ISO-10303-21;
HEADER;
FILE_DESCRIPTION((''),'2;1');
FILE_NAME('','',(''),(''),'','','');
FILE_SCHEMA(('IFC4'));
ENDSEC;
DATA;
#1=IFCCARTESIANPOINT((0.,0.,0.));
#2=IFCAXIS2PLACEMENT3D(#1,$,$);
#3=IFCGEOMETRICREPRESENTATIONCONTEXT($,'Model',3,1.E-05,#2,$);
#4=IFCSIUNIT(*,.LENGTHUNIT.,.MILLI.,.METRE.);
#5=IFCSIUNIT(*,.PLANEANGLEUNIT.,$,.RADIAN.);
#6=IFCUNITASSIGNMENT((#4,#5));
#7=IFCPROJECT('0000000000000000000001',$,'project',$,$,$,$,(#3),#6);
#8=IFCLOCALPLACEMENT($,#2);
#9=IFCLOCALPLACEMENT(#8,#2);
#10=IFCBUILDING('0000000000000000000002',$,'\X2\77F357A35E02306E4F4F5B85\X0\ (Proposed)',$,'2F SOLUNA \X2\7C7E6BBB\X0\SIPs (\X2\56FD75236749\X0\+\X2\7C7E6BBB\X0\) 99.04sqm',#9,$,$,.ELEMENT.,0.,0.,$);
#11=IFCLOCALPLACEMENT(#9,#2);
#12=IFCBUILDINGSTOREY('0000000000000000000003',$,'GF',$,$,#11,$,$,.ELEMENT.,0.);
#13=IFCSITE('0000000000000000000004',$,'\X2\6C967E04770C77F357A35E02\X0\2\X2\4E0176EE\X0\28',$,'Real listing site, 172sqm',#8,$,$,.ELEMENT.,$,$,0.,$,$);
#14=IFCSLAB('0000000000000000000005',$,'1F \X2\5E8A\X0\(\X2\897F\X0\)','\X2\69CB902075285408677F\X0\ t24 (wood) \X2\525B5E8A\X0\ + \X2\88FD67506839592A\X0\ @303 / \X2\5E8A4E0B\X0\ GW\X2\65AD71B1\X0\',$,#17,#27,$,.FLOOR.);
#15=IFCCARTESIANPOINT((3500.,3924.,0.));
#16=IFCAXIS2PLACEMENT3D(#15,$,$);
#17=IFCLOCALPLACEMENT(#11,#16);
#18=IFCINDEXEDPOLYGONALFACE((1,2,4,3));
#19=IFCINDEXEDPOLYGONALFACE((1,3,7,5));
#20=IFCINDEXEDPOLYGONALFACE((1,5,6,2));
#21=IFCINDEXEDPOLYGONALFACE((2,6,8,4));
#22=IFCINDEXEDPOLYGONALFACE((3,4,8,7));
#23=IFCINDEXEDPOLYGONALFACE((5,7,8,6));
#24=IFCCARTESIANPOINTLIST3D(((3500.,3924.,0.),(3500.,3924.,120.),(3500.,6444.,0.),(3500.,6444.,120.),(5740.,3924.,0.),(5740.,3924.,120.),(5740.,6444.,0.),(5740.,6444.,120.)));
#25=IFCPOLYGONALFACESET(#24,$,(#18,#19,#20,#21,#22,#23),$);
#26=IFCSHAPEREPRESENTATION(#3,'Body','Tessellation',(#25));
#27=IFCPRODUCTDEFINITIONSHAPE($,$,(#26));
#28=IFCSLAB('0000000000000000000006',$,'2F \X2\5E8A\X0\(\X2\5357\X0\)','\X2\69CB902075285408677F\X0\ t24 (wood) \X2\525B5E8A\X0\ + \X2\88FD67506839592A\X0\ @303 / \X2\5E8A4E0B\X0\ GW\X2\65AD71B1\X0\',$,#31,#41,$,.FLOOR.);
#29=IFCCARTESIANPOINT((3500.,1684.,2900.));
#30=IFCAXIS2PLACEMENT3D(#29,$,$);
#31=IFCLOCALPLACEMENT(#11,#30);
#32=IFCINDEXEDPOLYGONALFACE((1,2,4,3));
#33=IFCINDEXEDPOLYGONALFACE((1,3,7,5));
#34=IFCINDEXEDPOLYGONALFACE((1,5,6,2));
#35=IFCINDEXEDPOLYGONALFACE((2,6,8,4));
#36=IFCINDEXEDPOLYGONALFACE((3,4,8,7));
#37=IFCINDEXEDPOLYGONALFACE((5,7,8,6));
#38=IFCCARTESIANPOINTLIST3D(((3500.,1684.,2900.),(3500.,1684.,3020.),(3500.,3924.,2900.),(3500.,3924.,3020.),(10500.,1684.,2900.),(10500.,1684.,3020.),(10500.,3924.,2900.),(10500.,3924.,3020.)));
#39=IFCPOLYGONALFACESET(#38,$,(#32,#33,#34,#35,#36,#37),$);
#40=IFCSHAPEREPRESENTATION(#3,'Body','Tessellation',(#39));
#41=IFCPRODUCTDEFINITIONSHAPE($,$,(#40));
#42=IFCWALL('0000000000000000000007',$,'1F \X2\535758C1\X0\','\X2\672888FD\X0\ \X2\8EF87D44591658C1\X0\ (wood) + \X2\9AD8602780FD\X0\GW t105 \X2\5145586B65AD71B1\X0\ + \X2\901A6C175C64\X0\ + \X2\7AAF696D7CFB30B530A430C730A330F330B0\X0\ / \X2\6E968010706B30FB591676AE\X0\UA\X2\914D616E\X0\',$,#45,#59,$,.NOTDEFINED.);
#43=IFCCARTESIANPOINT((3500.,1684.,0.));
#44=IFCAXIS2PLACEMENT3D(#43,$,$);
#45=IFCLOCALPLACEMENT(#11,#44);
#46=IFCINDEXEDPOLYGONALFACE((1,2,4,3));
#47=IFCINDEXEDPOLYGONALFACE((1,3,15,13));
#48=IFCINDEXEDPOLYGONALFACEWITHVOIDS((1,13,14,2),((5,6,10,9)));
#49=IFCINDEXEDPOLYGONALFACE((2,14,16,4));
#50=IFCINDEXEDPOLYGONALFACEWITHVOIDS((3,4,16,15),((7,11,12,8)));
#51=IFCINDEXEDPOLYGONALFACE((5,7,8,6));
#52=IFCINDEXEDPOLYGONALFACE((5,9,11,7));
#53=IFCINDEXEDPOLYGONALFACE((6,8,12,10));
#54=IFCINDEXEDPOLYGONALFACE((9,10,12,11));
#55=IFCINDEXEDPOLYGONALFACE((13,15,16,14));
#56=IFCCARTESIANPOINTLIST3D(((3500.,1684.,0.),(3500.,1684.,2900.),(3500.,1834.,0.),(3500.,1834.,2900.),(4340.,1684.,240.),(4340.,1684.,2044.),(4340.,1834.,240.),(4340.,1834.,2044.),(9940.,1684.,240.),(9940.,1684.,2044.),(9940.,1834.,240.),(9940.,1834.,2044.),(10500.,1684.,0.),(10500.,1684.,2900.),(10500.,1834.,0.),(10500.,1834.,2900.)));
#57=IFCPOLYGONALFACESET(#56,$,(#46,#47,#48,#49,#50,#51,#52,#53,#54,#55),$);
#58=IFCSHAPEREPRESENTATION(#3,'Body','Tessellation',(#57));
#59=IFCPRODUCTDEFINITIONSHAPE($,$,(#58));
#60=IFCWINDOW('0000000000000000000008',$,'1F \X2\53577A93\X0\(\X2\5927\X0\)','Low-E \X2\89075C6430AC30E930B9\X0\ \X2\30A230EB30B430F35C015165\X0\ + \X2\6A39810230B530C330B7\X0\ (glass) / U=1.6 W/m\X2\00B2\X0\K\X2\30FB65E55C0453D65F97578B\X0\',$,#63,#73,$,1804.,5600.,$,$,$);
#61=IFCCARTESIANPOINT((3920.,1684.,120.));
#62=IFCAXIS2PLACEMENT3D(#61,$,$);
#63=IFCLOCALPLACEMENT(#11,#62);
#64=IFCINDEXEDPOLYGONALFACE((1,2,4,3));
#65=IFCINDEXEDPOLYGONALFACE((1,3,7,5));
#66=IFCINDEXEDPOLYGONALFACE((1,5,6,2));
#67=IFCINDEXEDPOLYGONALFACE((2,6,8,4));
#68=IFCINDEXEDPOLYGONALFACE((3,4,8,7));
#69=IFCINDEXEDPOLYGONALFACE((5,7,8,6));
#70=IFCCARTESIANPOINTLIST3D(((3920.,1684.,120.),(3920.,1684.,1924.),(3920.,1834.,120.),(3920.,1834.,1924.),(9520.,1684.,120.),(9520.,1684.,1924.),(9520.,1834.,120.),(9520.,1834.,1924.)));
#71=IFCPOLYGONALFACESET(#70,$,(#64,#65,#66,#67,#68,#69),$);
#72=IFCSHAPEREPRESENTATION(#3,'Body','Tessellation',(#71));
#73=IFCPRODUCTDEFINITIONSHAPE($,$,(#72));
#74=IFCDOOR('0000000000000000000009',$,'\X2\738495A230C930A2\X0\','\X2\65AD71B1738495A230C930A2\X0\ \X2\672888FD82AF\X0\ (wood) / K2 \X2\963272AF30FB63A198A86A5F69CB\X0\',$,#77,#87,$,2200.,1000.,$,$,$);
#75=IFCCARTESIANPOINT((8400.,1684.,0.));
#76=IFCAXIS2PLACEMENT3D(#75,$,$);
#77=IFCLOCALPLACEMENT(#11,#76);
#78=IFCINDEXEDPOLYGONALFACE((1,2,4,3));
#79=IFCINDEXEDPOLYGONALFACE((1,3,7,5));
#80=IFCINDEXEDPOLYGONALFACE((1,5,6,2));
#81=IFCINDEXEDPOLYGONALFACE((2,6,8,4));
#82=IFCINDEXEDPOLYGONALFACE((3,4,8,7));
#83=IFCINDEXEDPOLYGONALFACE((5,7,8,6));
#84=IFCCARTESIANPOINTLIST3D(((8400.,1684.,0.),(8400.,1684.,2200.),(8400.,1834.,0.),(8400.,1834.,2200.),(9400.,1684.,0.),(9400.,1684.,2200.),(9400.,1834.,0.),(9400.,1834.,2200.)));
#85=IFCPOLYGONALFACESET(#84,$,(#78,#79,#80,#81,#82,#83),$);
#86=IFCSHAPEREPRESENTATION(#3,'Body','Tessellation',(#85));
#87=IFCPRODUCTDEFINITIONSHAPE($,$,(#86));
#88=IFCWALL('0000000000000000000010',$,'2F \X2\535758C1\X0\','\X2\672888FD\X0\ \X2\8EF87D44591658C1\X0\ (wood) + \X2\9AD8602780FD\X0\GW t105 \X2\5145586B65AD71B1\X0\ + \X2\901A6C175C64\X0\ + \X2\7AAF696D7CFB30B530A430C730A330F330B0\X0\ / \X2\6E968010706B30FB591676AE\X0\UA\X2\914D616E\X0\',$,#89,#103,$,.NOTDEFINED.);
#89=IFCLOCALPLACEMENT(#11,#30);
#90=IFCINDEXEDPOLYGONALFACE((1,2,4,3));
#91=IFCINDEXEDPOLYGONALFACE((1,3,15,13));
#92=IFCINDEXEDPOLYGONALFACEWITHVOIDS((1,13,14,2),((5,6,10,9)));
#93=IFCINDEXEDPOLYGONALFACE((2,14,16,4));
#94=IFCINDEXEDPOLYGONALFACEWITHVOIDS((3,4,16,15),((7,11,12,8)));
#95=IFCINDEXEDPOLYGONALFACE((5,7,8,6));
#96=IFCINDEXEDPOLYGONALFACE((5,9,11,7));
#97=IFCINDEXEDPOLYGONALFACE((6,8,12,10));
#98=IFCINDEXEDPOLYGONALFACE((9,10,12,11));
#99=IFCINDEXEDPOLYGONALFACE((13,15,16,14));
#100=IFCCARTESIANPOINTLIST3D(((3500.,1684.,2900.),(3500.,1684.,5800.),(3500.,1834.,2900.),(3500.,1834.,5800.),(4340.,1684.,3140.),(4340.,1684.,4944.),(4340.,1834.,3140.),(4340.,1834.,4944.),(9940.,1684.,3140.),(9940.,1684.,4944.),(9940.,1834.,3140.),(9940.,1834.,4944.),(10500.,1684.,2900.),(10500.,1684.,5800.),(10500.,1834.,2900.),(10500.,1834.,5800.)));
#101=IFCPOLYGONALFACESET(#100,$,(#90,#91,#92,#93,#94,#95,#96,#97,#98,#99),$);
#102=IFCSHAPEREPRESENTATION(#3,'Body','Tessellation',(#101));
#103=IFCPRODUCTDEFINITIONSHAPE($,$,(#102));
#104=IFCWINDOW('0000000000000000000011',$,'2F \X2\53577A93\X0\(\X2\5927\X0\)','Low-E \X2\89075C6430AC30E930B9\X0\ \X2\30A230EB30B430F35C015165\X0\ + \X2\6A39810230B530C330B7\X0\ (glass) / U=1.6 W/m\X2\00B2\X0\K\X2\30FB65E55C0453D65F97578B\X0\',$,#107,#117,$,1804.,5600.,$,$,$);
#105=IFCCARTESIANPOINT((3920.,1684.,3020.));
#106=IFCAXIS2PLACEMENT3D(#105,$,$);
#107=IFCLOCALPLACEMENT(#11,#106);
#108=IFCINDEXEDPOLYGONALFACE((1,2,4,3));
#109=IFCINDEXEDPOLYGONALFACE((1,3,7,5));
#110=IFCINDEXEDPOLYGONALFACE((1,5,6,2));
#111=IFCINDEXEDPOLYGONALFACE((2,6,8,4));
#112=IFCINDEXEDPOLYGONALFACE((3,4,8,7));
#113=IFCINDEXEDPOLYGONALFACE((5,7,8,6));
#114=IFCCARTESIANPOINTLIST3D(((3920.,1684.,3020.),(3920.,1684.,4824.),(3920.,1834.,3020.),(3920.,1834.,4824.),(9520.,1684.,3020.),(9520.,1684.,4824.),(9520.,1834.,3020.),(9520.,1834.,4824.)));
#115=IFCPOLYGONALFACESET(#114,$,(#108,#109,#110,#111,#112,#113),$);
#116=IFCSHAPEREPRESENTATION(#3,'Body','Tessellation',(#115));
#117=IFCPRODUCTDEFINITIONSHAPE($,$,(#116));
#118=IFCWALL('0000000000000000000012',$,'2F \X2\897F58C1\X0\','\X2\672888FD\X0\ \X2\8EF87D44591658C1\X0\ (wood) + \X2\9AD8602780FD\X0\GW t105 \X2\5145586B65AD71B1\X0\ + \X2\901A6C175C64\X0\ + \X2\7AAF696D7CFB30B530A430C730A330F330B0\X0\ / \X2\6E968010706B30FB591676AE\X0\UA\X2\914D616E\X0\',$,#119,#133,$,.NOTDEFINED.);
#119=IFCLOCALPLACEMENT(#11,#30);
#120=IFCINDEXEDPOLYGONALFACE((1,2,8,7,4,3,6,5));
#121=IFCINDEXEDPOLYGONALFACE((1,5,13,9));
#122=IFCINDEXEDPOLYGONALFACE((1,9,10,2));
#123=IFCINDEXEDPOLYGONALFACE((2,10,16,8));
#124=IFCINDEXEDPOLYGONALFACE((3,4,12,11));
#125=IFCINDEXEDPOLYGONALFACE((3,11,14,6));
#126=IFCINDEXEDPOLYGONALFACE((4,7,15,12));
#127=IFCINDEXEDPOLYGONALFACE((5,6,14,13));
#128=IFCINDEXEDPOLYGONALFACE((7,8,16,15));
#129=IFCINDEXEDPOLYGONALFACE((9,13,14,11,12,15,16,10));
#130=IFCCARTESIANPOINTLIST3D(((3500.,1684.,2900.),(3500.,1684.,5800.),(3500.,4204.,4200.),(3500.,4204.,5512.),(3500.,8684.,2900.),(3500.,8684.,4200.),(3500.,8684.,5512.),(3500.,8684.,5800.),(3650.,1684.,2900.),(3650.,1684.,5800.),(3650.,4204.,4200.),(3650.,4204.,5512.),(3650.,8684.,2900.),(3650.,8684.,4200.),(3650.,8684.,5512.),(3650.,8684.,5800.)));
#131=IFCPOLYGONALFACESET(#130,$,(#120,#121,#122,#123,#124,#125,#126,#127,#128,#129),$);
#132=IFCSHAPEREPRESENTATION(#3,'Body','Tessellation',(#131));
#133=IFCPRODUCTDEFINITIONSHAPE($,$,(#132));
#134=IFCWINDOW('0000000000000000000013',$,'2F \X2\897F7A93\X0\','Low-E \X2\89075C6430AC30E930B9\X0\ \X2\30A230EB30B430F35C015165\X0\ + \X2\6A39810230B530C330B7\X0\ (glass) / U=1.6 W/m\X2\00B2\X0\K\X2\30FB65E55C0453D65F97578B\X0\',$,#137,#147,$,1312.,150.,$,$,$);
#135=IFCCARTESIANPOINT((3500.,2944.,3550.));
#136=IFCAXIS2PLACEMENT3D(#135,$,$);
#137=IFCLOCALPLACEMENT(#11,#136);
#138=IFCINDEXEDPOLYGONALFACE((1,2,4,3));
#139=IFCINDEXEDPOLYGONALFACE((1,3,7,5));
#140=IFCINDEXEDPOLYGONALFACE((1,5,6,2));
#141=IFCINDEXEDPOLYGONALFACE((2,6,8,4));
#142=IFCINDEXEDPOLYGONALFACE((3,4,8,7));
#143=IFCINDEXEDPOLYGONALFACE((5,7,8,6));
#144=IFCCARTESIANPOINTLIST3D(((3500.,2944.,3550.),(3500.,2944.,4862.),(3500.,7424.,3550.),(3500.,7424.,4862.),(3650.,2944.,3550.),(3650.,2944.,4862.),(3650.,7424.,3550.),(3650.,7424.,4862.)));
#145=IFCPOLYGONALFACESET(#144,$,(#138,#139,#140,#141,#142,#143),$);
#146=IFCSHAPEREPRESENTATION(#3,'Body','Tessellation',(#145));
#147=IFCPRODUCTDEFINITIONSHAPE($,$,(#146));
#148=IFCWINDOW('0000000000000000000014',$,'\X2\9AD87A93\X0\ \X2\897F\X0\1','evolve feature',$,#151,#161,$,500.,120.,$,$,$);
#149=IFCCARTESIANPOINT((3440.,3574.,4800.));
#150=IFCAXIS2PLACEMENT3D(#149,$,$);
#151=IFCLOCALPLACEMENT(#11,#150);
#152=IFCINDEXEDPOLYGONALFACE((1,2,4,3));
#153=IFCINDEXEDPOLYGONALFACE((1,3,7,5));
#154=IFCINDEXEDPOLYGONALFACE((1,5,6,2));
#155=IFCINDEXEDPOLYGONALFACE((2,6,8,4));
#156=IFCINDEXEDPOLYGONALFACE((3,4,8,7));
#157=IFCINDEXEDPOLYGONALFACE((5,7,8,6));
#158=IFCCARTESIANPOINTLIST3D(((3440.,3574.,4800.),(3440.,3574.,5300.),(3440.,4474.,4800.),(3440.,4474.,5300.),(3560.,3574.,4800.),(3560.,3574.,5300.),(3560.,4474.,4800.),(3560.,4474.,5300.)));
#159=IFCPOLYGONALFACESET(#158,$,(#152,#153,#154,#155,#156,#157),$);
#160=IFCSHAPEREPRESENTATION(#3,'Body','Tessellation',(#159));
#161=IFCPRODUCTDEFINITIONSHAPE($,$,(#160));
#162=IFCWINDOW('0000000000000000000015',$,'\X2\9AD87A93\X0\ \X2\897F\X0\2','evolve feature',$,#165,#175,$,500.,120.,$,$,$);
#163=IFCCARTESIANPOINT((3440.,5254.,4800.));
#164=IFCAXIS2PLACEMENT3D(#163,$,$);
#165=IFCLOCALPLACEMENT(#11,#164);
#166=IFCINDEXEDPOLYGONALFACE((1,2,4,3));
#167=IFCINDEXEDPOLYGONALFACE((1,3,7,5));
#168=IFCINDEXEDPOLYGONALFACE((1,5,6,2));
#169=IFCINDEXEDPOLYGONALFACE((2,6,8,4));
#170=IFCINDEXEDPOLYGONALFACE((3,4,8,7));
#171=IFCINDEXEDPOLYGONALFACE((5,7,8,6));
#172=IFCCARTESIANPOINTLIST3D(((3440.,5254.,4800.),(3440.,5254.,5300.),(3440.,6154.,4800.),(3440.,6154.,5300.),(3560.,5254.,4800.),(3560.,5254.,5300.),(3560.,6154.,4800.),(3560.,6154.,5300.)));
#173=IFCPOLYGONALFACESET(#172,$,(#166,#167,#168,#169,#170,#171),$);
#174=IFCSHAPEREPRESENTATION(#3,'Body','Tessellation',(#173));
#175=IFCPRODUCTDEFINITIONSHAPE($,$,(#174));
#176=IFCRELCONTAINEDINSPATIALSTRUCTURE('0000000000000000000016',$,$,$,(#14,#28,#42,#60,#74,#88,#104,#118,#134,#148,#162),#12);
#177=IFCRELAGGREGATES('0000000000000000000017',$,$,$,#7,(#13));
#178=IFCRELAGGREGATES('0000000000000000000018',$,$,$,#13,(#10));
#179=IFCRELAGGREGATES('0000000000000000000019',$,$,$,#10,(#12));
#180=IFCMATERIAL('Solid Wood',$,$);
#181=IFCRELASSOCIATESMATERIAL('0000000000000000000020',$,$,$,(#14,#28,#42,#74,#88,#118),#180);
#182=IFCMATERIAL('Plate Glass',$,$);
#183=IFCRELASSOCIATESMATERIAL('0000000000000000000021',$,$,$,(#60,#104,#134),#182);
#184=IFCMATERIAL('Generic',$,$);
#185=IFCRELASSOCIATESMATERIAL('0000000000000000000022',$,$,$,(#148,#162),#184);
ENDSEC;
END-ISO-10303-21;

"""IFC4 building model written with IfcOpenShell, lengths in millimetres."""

from ifc_helpers import new_model, si_unit, frame, frame_2d, origin, place, context, project, spatial, rectangle, extrude, material, element, fill, save


model = new_model("IFC4")

# Units and contexts
model_context = context("Model", 3, precision=1e-05, world=origin())
ifc_project = project(units=[si_unit("LENGTHUNIT", "METRE", prefix="MILLI"), si_unit("PLANEANGLEUNIT", "RADIAN")], contexts=[model_context])

# Site, building, storey
site_placement = place(None, origin())
site = spatial("IfcSite", under=ifc_project, at=site_placement, Name="沖縄県石垣市2丁目28", ObjectType="Real listing site, 172sqm", CompositionType="ELEMENT", RefElevation=0.0)
building_placement = place(site_placement, origin())
building = spatial("IfcBuilding", under=site, at=building_placement, Name="石垣市の住宅 (Proposed)", ObjectType="2F SOLUNA 籾殻SIPs (国産杉+籾殻) 99.04sqm", CompositionType="ELEMENT", ElevationOfRefHeight=0.0, ElevationOfTerrain=0.0)
storey_placement = place(building_placement, origin())
storey = spatial("IfcBuildingStorey", under=building, at=storey_placement, Name="GF", CompositionType="ELEMENT", Elevation=0.0)

# Slabs
ifc_material_1 = material(Name="Solid Wood")
slab_1_placement = place(storey_placement, frame((3500.0, 3924.0, 0.0)))
element("IfcSlab", 1, at=slab_1_placement, inside=storey, material=ifc_material_1, Name="1F 床(西)", Description="構造用合板 t24 (wood) 剛床 + 製材根太 @303 / 床下 GW断熱", PredefinedType="FLOOR", context=model_context, shape_type="SweptSolid", body=[
    extrude(rectangle(XDim=2240.0, YDim=2520.0, at=frame_2d((1120.0, 1260.0))), frame((3500.0, 3924.0, 0.0)), (0.0, 0.0, 1.0), 120.0),
])
slab_2_placement = place(storey_placement, frame((3500.0, 1684.0, 2900.0)))
element("IfcSlab", 2, at=slab_2_placement, inside=storey, material=ifc_material_1, Name="2F 床(南)", Description="構造用合板 t24 (wood) 剛床 + 製材根太 @303 / 床下 GW断熱", PredefinedType="FLOOR", context=model_context, shape_type="SweptSolid", body=[
    extrude(rectangle(XDim=7000.0, YDim=2240.0, at=frame_2d((3500.0, 1120.0))), frame((3500.0, 1684.0, 2900.0)), (0.0, 0.0, 1.0), 120.0),
])
ifc_material_2 = material(Name="Generic")

# Wall, openings, window, door
wall_1_placement = place(storey_placement, frame((3500.0, 1684.0, 0.0)))
wall_1 = element("IfcWall", 3, at=wall_1_placement, inside=storey, material=ifc_material_1, Name="1F 南壁", Description="木製 軸組外壁 (wood) + 高性能GW t105 充填断熱 + 通気層 + 窯業系サイディング / 準耐火・外皮UA配慮", PredefinedType="NOTDEFINED", context=model_context, shape_type="SweptSolid", body=[
    extrude(rectangle(XDim=7000.0, YDim=150.0, at=frame_2d((3500.0, 75.0))), frame((3500.0, 1684.0, 0.0)), (0.0, 0.0, 1.0), 2900.0),
])
opening_1_placement = place(storey_placement, frame((3920.0, 1684.0, 120.0)))
opening_1 = element("IfcOpeningElement", 4, at=opening_1_placement, cuts=wall_1, PredefinedType="NOTDEFINED", context=model_context, shape_type="SweptSolid", body=[
    extrude(rectangle(XDim=5600.0, YDim=150.0, at=frame_2d((2800.0, 75.0))), frame((3920.0, 1684.0, 120.0)), (0.0, 0.0, 1.0), 1804.0),
])
opening_2_placement = place(storey_placement, frame((8400.0, 1684.0, 0.0)))
opening_2 = element("IfcOpeningElement", 5, at=opening_2_placement, cuts=wall_1, PredefinedType="NOTDEFINED", context=model_context, shape_type="SweptSolid", body=[
    extrude(rectangle(XDim=1000.0, YDim=150.0, at=frame_2d((500.0, 75.0))), frame((8400.0, 1684.0, 0.0)), (0.0, 0.0, 1.0), 2200.0),
])
ifc_material_3 = material(Name="Plate Glass")
window_1_placement = place(storey_placement, frame((3920.0, 1684.0, 120.0)))
window_1 = element("IfcWindow", 6, at=window_1_placement, inside=storey, material=ifc_material_3, Name="1F 南窓(大)", Description="Low-E 複層ガラス アルゴン封入 + 樹脂サッシ (glass) / U=1.6 W/m²K・日射取得型", OverallHeight=1804.0, OverallWidth=5600.0, context=model_context, shape_type="SweptSolid", body=[
    extrude(rectangle(XDim=5600.0, YDim=150.0, at=frame_2d((2800.0, 75.0))), frame((3920.0, 1684.0, 120.0)), (0.0, 0.0, 1.0), 1804.0),
])
fill(opening_1, window_1)
door_placement = place(storey_placement, frame((8400.0, 1684.0, 0.0)))
door = element("IfcDoor", 7, at=door_placement, inside=storey, material=ifc_material_1, Name="玄関ドア", Description="断熱玄関ドア 木製芯 (wood) / K2 防犯・採風機構", OverallHeight=2200.0, OverallWidth=1000.0, context=model_context, shape_type="SweptSolid", body=[
    extrude(rectangle(XDim=1000.0, YDim=150.0, at=frame_2d((500.0, 75.0))), frame((8400.0, 1684.0, 0.0)), (0.0, 0.0, 1.0), 2200.0),
])
fill(opening_2, door)

# Wall, opening, window
wall_2_placement = place(storey_placement, frame((3500.0, 1684.0, 2900.0)))
wall_2 = element("IfcWall", 8, at=wall_2_placement, inside=storey, material=ifc_material_1, Name="2F 南壁", Description="木製 軸組外壁 (wood) + 高性能GW t105 充填断熱 + 通気層 + 窯業系サイディング / 準耐火・外皮UA配慮", PredefinedType="NOTDEFINED", context=model_context, shape_type="SweptSolid", body=[
    extrude(rectangle(XDim=7000.0, YDim=150.0, at=frame_2d((3500.0, 75.0))), frame((3500.0, 1684.0, 2900.0)), (0.0, 0.0, 1.0), 2900.0),
])
opening_3_placement = place(storey_placement, frame((3920.0, 1684.0, 3020.0)))
opening_3 = element("IfcOpeningElement", 9, at=opening_3_placement, cuts=wall_2, PredefinedType="NOTDEFINED", context=model_context, shape_type="SweptSolid", body=[
    extrude(rectangle(XDim=5600.0, YDim=150.0, at=frame_2d((2800.0, 75.0))), frame((3920.0, 1684.0, 3020.0)), (0.0, 0.0, 1.0), 1804.0),
])
window_2_placement = place(storey_placement, frame((3920.0, 1684.0, 3020.0)))
window_2 = element("IfcWindow", 10, at=window_2_placement, inside=storey, material=ifc_material_3, Name="2F 南窓(大)", Description="Low-E 複層ガラス アルゴン封入 + 樹脂サッシ (glass) / U=1.6 W/m²K・日射取得型", OverallHeight=1804.0, OverallWidth=5600.0, context=model_context, shape_type="SweptSolid", body=[
    extrude(rectangle(XDim=5600.0, YDim=150.0, at=frame_2d((2800.0, 75.0))), frame((3920.0, 1684.0, 3020.0)), (0.0, 0.0, 1.0), 1804.0),
])
fill(opening_3, window_2)

# Wall, openings, windows
wall_3_placement = place(storey_placement, frame((3500.0, 1684.0, 2900.0)))
wall_3 = element("IfcWall", 11, at=wall_3_placement, inside=storey, material=ifc_material_1, Name="2F 西壁", Description="木製 軸組外壁 (wood) + 高性能GW t105 充填断熱 + 通気層 + 窯業系サイディング / 準耐火・外皮UA配慮", PredefinedType="NOTDEFINED", context=model_context, shape_type="SweptSolid", body=[
    extrude(rectangle(XDim=150.0, YDim=7000.0, at=frame_2d((75.0, 3500.0))), frame((3500.0, 1684.0, 2900.0)), (0.0, 0.0, 1.0), 2900.0),
])
opening_4_placement = place(storey_placement, frame((3500.0, 2944.0, 3550.0)))
opening_4 = element("IfcOpeningElement", 12, at=opening_4_placement, cuts=wall_3, PredefinedType="NOTDEFINED", context=model_context, shape_type="SweptSolid", body=[
    extrude(rectangle(XDim=150.0, YDim=4480.0, at=frame_2d((75.0, 2240.0))), frame((3500.0, 2944.0, 3550.0)), (0.0, 0.0, 1.0), 1312.0),
])
opening_5_placement = place(storey_placement, frame((3440.0, 3574.0, 4800.0)))
opening_5 = element("IfcOpeningElement", 13, at=opening_5_placement, cuts=wall_3, PredefinedType="NOTDEFINED", context=model_context, shape_type="SweptSolid", body=[
    extrude(rectangle(XDim=120.0, YDim=900.0, at=frame_2d((60.0, 450.0))), frame((3440.0, 3574.0, 4800.0)), (0.0, 0.0, 1.0), 500.0),
])
opening_6_placement = place(storey_placement, frame((3440.0, 5254.0, 4800.0)))
opening_6 = element("IfcOpeningElement", 14, at=opening_6_placement, cuts=wall_3, PredefinedType="NOTDEFINED", context=model_context, shape_type="SweptSolid", body=[
    extrude(rectangle(XDim=120.0, YDim=900.0, at=frame_2d((60.0, 450.0))), frame((3440.0, 5254.0, 4800.0)), (0.0, 0.0, 1.0), 500.0),
])
window_3_placement = place(storey_placement, frame((3500.0, 2944.0, 3550.0)))
window_3 = element("IfcWindow", 15, at=window_3_placement, inside=storey, material=ifc_material_3, Name="2F 西窓", Description="Low-E 複層ガラス アルゴン封入 + 樹脂サッシ (glass) / U=1.6 W/m²K・日射取得型", OverallHeight=1312.0, OverallWidth=150.0, context=model_context, shape_type="SweptSolid", body=[
    extrude(rectangle(XDim=150.0, YDim=4480.0, at=frame_2d((75.0, 2240.0))), frame((3500.0, 2944.0, 3550.0)), (0.0, 0.0, 1.0), 1312.0),
])
fill(opening_4, window_3)
window_4_placement = place(storey_placement, frame((3440.0, 3574.0, 4800.0)))
window_4 = element("IfcWindow", 16, at=window_4_placement, inside=storey, material=ifc_material_2, Name="高窓 西1", Description="evolve feature", OverallHeight=500.0, OverallWidth=120.0, context=model_context, shape_type="SweptSolid", body=[
    extrude(rectangle(XDim=120.0, YDim=900.0, at=frame_2d((60.0, 450.0))), frame((3440.0, 3574.0, 4800.0)), (0.0, 0.0, 1.0), 500.0),
])
fill(opening_5, window_4)
window_5_placement = place(storey_placement, frame((3440.0, 5254.0, 4800.0)))
window_5 = element("IfcWindow", 17, at=window_5_placement, inside=storey, material=ifc_material_2, Name="高窓 西2", Description="evolve feature", OverallHeight=500.0, OverallWidth=120.0, context=model_context, shape_type="SweptSolid", body=[
    extrude(rectangle(XDim=120.0, YDim=900.0, at=frame_2d((60.0, 450.0))), frame((3440.0, 5254.0, 4800.0)), (0.0, 0.0, 1.0), 500.0),
])
fill(opening_6, window_5)

save(model, "model.ifc")
